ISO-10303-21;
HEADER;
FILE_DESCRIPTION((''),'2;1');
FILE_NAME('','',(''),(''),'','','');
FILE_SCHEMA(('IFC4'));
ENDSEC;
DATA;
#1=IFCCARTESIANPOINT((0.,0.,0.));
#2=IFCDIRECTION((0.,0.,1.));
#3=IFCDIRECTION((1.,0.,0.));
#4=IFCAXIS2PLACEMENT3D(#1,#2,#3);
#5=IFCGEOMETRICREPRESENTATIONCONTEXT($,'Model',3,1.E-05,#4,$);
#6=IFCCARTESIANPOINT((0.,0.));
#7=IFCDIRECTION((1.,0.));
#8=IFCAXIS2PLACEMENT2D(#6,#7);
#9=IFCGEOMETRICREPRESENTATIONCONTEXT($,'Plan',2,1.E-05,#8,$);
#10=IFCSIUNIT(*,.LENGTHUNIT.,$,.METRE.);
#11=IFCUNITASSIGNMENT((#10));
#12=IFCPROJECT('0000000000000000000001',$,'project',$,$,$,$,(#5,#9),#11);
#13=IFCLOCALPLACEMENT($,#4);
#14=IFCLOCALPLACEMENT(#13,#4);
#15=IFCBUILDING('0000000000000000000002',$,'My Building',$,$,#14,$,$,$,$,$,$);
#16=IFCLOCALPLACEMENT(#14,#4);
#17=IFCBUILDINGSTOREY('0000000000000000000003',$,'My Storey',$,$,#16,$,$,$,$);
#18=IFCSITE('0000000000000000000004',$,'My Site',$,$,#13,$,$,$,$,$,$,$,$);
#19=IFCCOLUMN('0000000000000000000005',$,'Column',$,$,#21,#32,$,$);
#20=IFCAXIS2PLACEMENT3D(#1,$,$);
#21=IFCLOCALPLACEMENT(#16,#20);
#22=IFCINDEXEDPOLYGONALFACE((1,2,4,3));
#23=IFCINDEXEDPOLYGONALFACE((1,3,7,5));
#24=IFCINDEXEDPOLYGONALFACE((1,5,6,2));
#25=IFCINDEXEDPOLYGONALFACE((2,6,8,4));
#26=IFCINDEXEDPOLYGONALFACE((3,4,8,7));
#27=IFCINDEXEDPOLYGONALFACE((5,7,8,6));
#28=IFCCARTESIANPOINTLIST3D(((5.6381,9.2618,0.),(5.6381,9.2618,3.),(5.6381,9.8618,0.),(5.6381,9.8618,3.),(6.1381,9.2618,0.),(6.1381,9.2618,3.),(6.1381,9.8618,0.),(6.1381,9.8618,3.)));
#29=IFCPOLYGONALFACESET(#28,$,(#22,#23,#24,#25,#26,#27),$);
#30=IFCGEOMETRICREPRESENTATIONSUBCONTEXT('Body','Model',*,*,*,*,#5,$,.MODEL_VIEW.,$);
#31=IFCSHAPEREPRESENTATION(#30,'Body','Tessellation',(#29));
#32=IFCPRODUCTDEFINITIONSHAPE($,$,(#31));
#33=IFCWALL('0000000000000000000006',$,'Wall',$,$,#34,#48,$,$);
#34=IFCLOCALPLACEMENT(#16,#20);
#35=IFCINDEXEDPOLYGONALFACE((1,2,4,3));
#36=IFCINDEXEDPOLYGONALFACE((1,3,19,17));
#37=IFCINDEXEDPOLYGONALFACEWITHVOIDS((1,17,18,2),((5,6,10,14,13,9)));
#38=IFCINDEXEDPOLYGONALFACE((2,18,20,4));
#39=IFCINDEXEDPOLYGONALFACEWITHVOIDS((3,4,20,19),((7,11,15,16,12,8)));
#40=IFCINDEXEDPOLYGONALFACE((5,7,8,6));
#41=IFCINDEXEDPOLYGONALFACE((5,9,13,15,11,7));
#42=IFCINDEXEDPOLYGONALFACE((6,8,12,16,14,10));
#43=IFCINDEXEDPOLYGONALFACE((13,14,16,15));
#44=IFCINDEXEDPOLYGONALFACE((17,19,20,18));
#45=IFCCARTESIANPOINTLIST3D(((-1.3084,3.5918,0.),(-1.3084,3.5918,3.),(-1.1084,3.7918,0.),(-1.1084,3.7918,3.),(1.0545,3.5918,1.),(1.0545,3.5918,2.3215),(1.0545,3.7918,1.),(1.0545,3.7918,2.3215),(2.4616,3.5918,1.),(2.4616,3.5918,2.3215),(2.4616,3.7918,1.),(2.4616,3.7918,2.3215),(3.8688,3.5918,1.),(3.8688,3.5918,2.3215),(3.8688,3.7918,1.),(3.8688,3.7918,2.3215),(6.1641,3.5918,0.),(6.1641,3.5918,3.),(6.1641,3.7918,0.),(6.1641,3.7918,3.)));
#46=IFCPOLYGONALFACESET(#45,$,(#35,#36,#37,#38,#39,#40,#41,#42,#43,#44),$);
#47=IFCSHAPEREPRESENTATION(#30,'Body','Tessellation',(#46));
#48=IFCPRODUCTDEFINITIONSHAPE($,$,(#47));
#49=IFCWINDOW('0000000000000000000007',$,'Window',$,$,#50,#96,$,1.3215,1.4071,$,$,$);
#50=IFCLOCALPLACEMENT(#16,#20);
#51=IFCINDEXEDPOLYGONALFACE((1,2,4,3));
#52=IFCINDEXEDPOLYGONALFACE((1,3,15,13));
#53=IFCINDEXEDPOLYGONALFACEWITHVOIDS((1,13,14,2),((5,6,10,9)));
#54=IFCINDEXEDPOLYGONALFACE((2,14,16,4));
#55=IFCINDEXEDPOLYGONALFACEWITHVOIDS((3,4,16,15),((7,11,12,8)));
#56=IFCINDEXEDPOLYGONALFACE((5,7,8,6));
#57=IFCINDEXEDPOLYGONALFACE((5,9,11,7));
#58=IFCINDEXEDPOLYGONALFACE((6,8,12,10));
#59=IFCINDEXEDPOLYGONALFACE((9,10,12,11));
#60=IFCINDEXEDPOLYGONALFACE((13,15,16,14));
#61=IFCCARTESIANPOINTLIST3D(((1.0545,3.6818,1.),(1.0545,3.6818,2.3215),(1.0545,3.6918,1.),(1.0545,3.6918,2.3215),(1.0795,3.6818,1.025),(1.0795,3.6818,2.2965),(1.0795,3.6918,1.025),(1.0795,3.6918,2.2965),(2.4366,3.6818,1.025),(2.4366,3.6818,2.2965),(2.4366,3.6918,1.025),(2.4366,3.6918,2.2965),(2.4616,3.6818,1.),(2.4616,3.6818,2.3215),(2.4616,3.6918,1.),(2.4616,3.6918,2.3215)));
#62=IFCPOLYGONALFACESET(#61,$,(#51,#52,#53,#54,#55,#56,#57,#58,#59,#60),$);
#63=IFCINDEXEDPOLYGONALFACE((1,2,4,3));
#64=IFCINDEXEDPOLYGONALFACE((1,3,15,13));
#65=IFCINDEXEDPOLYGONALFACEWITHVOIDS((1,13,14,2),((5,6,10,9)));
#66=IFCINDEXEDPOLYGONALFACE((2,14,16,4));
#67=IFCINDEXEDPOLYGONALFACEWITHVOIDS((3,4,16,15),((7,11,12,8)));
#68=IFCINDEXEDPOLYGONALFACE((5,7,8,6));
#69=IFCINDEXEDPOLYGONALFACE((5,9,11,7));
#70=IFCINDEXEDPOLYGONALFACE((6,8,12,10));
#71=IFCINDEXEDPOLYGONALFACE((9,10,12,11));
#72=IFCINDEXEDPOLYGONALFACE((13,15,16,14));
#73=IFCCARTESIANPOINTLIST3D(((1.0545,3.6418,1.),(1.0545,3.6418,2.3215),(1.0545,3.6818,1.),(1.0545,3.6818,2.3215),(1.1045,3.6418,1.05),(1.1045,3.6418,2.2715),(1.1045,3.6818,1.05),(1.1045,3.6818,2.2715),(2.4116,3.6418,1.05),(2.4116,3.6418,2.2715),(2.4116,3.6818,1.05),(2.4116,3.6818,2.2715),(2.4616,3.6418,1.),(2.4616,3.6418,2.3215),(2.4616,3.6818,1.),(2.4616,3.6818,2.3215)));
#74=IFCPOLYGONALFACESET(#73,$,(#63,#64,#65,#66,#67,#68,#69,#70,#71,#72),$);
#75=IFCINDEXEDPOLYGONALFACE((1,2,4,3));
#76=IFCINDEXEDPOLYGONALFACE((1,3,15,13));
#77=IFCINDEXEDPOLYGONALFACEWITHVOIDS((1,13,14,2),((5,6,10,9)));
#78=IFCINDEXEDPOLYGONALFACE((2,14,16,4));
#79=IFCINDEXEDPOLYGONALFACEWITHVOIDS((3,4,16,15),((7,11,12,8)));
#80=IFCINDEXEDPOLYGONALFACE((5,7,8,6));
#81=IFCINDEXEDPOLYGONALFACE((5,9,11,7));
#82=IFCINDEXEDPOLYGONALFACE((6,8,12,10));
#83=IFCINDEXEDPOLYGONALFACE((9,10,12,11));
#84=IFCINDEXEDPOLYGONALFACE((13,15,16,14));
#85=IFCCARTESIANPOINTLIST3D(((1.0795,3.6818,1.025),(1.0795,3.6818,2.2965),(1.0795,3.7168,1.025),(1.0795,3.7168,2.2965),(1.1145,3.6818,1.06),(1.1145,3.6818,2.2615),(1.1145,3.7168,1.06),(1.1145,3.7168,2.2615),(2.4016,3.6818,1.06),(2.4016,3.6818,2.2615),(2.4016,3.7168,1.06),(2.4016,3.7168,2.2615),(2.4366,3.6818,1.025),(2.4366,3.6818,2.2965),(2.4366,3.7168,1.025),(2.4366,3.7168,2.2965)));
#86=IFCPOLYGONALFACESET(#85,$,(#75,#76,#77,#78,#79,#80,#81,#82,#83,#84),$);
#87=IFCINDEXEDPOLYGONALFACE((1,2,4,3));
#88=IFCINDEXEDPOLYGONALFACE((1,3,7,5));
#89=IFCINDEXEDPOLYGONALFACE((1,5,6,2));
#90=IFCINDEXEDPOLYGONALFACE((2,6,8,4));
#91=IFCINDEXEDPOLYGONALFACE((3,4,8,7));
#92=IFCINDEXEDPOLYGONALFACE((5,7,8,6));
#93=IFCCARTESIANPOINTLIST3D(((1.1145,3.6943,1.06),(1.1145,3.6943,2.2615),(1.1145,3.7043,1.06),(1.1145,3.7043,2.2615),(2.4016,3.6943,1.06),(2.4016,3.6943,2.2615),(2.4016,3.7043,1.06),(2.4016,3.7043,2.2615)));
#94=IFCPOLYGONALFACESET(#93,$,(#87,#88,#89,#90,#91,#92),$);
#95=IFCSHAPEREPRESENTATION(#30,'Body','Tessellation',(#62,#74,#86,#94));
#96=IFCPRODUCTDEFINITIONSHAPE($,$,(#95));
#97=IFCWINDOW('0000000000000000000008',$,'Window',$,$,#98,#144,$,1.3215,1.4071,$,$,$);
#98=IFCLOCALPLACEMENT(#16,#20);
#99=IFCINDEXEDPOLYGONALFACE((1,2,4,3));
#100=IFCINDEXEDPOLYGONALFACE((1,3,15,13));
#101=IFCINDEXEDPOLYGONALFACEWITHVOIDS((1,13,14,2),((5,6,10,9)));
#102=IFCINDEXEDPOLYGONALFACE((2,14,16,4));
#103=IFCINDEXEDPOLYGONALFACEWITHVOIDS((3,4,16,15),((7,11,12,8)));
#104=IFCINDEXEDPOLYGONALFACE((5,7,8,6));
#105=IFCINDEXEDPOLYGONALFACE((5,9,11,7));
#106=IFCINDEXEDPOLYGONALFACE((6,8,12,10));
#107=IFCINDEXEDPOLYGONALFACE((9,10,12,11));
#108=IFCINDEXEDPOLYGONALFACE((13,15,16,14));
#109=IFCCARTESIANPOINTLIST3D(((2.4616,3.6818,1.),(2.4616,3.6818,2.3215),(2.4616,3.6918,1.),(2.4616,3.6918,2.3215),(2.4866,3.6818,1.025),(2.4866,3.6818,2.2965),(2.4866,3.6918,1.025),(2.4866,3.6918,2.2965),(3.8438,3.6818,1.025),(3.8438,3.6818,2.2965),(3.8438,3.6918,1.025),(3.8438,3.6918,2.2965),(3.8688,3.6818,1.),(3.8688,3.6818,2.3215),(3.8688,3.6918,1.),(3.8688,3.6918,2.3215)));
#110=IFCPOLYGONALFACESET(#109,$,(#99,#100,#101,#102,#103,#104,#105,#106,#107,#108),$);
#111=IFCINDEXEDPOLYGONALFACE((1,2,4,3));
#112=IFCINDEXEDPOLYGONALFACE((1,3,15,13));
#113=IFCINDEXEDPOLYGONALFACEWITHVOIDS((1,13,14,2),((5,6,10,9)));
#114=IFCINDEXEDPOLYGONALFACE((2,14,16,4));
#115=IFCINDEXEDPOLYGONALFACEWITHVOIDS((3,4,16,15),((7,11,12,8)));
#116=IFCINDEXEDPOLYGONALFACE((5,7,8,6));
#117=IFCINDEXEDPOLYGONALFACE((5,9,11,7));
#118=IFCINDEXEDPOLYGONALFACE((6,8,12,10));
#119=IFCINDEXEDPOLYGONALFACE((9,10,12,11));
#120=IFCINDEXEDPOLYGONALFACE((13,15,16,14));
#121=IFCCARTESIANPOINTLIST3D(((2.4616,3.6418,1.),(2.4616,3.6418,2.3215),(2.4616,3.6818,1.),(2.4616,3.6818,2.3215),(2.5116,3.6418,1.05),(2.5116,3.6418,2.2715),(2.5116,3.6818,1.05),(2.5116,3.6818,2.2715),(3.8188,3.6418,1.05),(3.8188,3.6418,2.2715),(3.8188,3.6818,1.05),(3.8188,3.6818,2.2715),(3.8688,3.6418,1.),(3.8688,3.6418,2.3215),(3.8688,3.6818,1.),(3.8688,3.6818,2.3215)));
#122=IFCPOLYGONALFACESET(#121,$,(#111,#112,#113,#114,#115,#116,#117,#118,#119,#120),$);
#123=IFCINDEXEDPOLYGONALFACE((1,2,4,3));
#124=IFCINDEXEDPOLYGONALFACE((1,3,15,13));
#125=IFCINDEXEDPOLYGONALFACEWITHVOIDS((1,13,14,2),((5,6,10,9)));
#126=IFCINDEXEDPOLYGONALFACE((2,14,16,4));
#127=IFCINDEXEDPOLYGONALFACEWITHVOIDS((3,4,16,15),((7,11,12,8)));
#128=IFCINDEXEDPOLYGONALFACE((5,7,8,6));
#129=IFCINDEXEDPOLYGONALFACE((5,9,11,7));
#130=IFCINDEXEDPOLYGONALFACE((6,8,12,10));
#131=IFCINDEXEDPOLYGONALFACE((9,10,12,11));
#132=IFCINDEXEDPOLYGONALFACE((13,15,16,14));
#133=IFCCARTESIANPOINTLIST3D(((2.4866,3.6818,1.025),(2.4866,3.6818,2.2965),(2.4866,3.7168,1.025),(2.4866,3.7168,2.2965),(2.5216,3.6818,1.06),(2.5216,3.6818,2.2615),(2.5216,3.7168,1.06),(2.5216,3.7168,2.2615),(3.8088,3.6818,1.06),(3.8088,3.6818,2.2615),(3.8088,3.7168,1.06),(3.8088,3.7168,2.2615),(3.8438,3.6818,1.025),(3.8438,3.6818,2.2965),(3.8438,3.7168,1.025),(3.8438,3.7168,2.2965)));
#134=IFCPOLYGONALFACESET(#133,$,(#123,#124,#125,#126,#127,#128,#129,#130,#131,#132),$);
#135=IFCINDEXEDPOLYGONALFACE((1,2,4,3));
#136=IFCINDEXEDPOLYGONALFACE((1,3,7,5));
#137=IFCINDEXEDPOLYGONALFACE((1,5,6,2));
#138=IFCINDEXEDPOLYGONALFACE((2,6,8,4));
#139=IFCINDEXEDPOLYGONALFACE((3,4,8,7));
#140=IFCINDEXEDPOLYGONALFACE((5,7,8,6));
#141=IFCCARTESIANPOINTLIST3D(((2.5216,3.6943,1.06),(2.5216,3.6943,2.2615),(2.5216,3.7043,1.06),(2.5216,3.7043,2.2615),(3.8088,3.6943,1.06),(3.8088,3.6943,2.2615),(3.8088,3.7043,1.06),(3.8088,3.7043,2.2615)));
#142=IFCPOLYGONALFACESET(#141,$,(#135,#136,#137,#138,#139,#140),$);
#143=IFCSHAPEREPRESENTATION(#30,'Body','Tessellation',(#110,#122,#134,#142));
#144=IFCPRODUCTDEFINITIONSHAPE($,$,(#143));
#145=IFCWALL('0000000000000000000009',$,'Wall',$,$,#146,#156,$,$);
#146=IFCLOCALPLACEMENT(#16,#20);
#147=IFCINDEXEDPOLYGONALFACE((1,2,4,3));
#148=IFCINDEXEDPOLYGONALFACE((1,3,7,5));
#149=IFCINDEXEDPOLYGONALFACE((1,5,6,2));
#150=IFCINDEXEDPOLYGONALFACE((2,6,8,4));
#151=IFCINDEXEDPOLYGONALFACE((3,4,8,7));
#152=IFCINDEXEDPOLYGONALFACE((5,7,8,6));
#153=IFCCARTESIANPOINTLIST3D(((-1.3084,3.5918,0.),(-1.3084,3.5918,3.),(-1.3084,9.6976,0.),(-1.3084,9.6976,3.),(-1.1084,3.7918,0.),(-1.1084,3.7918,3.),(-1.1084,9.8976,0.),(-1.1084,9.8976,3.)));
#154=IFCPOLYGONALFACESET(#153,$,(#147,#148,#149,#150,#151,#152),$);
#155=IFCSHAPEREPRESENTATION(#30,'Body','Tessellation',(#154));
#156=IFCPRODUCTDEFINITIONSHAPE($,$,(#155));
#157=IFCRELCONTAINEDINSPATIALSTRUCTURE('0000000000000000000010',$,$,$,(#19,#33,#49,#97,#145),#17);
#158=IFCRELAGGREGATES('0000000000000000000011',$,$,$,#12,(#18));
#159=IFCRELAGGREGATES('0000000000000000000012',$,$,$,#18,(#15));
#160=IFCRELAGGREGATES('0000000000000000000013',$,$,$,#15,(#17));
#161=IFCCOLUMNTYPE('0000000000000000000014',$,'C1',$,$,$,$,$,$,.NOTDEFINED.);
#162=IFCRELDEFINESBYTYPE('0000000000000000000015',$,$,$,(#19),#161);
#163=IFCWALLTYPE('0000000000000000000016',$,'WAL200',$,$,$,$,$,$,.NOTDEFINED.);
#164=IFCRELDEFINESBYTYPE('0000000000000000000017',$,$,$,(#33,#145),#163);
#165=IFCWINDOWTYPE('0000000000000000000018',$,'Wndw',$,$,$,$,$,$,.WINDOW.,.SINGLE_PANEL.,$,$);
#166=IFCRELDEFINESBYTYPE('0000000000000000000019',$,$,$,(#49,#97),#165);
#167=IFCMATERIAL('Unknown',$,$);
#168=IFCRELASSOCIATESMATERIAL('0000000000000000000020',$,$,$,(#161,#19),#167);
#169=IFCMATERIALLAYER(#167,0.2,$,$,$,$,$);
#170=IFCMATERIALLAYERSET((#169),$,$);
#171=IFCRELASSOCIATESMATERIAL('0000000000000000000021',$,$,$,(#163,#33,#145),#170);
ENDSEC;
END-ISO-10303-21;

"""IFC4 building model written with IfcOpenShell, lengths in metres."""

from ifc_helpers import new_model, entity, si_unit, frame, origin_with_axes, origin_2d_with_axis, place, context, subcontext, project, spatial, line, indexed_curve, rectangle, outline, extrude, shape, source, transform, mapped, material, layer, layer_set, layer_usage, material_profile, profile_set, profile_usage, type_object, type_shapes, element, fill, save


model = new_model("IFC4")

# Units and contexts
model_context = context("Model", 3, precision=1e-05, world=origin_with_axes())
plan_context = context("Plan", 2, precision=1e-05, world=origin_2d_with_axis())
body_context_1 = subcontext(model_context, "Body", "Model", "MODEL_VIEW")
body_context_2 = subcontext(plan_context, "Body", "Plan", "PLAN_VIEW")
ifc_project = project(units=[si_unit("LENGTHUNIT", "METRE")], contexts=[model_context, plan_context])

# Site, building, storey
site_placement = place(None, origin_with_axes())
site = spatial("IfcSite", under=ifc_project, at=site_placement, Name="My Site")
building_placement = place(site_placement, origin_with_axes())
building = spatial("IfcBuilding", under=site, at=building_placement, Name="My Building")
storey_placement = place(building_placement, origin_with_axes())
storey = spatial("IfcBuildingStorey", under=building, at=storey_placement, Name="My Storey")

# Column
ifc_material = material(Name="Unknown")
ifc_material_profile = material_profile(ifc_material, rectangle(XDim=0.5, YDim=0.6))
ifc_profile_set = profile_set([ifc_material_profile])
ifc_profile_usage = profile_usage(ifc_profile_set, cardinal=5)
column_type = type_object("IfcColumnType", Name="C1", PredefinedType="NOTDEFINED", material=ifc_profile_set)
column_placement = place(storey_placement, frame((5.8881, 9.5618, 0.0), z_axis=(0.0, 0.0, 1.0), x_axis=(1.0, 0.0, 0.0)))
element("IfcColumn", 1, at=column_placement, inside=storey, type_object=column_type, material=ifc_profile_usage, Name="Column", context=body_context_1, shape_type="SweptSolid", body=[
    extrude(rectangle(XDim=0.5, YDim=0.6), origin_with_axes(), (0.0, 0.0, 1.0), 3.0),
])

# Wall, openings, windows
ifc_layer = layer(ifc_material, 0.2)
ifc_layer_set = layer_set([ifc_layer])
ifc_layer_usage_1 = layer_usage(ifc_layer_set, "AXIS2", "POSITIVE", 0.0)
wall_type = type_object("IfcWallType", Name="WAL200", PredefinedType="NOTDEFINED", material=ifc_layer_set)
wall_1_placement = place(storey_placement, frame((6.1641, 3.7918, 0.0), z_axis=(0.0, 0.0, 1.0), x_axis=(-1.0, 0.0, 0.0)))
wall_1 = element("IfcWall", 2, at=wall_1_placement, inside=storey, type_object=wall_type, material=ifc_layer_usage_1, Name="Wall", context=body_context_1, shape_type="SweptSolid", body=[
    extrude(outline(indexed_curve([(0.0, 0.0), (0.0, 0.2), (7.4725, 0.2), (7.2725, 0.0)], segments=[line(1, 2, 3, 4, 1)])), origin_with_axes(), (0.0, 0.0, 1.0), 3.0),
])
shared_shape_1 = source(origin_with_axes(), body_context_1, "Body", "SweptSolid", [
    extrude(outline(indexed_curve([(0.0, 0.0), (1.4071, 0.0), (1.4071, 1.3215), (0.0, 1.3215)], segments=[line(1, 2, 3, 4, 1)])), frame((0.0, -0.6, 0.0), z_axis=(0.0, -1.0, 0.0), x_axis=(1.0, 0.0, 0.0)), (0.0, 0.0, -1.0), 1.2),
])
opening_1_placement = place(wall_1_placement, frame((5.1096, 0.2, 1.0), z_axis=(0.0, 0.0, 1.0), x_axis=(-1.0, 0.0, 0.0)))
opening_1 = element("IfcOpeningElement", 3, at=opening_1_placement, cuts=wall_1, PredefinedType="OPENING", context=body_context_1, shape_type="MappedRepresentation", body=[
    mapped(shared_shape_1, transform((0.0, 0.0, 0.0), x_axis=(1.0, 0.0, 0.0), y_axis=(0.0, 1.0, 0.0), z_axis=(0.0, 0.0, 1.0), scale=1.0)),
])
opening_2_placement = place(wall_1_placement, frame((3.7025, 0.2, 1.0), z_axis=(0.0, 0.0, 1.0), x_axis=(-1.0, 0.0, 0.0)))
opening_2 = element("IfcOpeningElement", 4, at=opening_2_placement, cuts=wall_1, PredefinedType="OPENING", context=body_context_1, shape_type="MappedRepresentation", body=[
    mapped(shared_shape_1, transform((0.0, 0.0, 0.0), x_axis=(1.0, 0.0, 0.0), y_axis=(0.0, 1.0, 0.0), z_axis=(0.0, 0.0, 1.0), scale=1.0)),
])
window_type = type_object("IfcWindowType", Name="Wndw", PartitioningType="SINGLE_PANEL", PredefinedType="WINDOW")
shared_shape_2 = source(origin_with_axes(), body_context_1, "Body", "SweptSolid", [
    extrude(outline(indexed_curve([(0.0, 0.0), (1.4071, 0.0), (1.4071, 1.3215), (0.0, 1.3215)], segments=[line(1, 2, 3, 4, 1)]), holes=[indexed_curve([(0.025, 0.025), (1.3821, 0.025), (1.3821, 1.2965), (0.025, 1.2965)], segments=[line(1, 2, 3, 4, 1)])]), frame((0.0, 0.09, 0.0), z_axis=(0.0, -1.0, 0.0), x_axis=(1.0, 0.0, 0.0)), (0.0, 0.0, -1.0), 0.01),
    extrude(outline(indexed_curve([(0.0, 0.0), (1.4071, 0.0), (1.4071, 1.3215), (0.0, 1.3215)], segments=[line(1, 2, 3, 4, 1)]), holes=[indexed_curve([(0.05, 0.05), (1.3571, 0.05), (1.3571, 1.2715), (0.05, 1.2715)], segments=[line(1, 2, 3, 4, 1)])]), frame((0.0, 0.05, 0.0), z_axis=(0.0, -1.0, 0.0), x_axis=(1.0, 0.0, 0.0)), (0.0, 0.0, -1.0), 0.04),
    extrude(outline(indexed_curve([(0.0, 0.0), (1.3571, 0.0), (1.3571, 1.2715), (0.0, 1.2715)], segments=[line(1, 2, 3, 4, 1)]), holes=[indexed_curve([(0.035, 0.035), (1.3221, 0.035), (1.3221, 1.2365), (0.035, 1.2365)], segments=[line(1, 2, 3, 4, 1)])]), frame((0.025, 0.09, 0.025), z_axis=(0.0, -1.0, 0.0), x_axis=(1.0, 0.0, 0.0)), (0.0, 0.0, -1.0), 0.035),
    extrude(outline(indexed_curve([(0.035, 0.035), (1.3221, 0.035), (1.3221, 1.2365), (0.035, 1.2365)], segments=[line(1, 2, 3, 4, 1)])), frame((0.025, 0.1025, 0.025), z_axis=(0.0, -1.0, 0.0), x_axis=(1.0, 0.0, 0.0)), (0.0, 0.0, -1.0), 0.01),
])
shared_shape_3 = source(origin_with_axes(), body_context_2, "Body", "Curve2D", [
    entity("IfcIndexedPolyCurve", entity("IfcCartesianPointList2D", [[0.05, 0.05], [1.3571, 0.05]])),
    entity("IfcIndexedPolyCurve", entity("IfcCartesianPointList2D", [[0.0, 0.1], [0.025, 0.1], [0.025, 0.09], [0.05, 0.09], [0.05, 0.05], [0.0, 0.05]]), [entity("IfcLineIndex", [1, 2, 3, 4, 5, 6, 1])]),
    entity("IfcIndexedPolyCurve", entity("IfcCartesianPointList2D", [[1.4071, 0.1], [1.3821, 0.1], [1.3821, 0.09], [1.3571, 0.09], [1.3571, 0.05], [1.4071, 0.05]]), [entity("IfcLineIndex", [1, 2, 3, 4, 5, 6, 1])]),
    entity("IfcIndexedPolyCurve", entity("IfcCartesianPointList2D", [[0.025, 0.09], [0.06, 0.09], [0.06, 0.125], [0.025, 0.125]]), [entity("IfcLineIndex", [1, 2, 3, 4, 1])]),
    entity("IfcIndexedPolyCurve", entity("IfcCartesianPointList2D", [[1.3821, 0.09], [1.3471, 0.09], [1.3471, 0.125], [1.3821, 0.125]]), [entity("IfcLineIndex", [1, 2, 3, 4, 1])]),
    entity("IfcIndexedPolyCurve", entity("IfcCartesianPointList2D", [[0.06, 0.09], [1.3471, 0.09]])),
    entity("IfcIndexedPolyCurve", entity("IfcCartesianPointList2D", [[0.06, 0.125], [1.3471, 0.125]])),
    entity("IfcIndexedPolyCurve", entity("IfcCartesianPointList2D", [[0.06, 0.1075], [1.3471, 0.1075]])),
])
type_shapes(window_type, [shared_shape_2, shared_shape_3])
window_1_placement = place(opening_1_placement, frame((0.0, 0.0, 0.0), z_axis=(0.0, 0.0, 1.0), x_axis=(1.0, 0.0, 0.0)))
window_1 = element("IfcWindow", 5, at=window_1_placement, inside=storey, type_object=window_type, Name="Window", OverallHeight=1.3215, OverallWidth=1.4071, shapes=[
    shape(body_context_1, "Body", "MappedRepresentation", [mapped(shared_shape_2, transform((0.0, 0.0, 0.0), x_axis=(1.0, 0.0, 0.0), y_axis=(0.0, 1.0, 0.0), z_axis=(0.0, 0.0, 1.0), scale=1.0))]),
    shape(body_context_2, "Body", "MappedRepresentation", [mapped(shared_shape_3, transform((0.0, 0.0, 0.0), x_axis=(1.0, 0.0, 0.0), y_axis=(0.0, 1.0, 0.0), z_axis=(0.0, 0.0, 1.0), scale=1.0))]),
])
fill(opening_1, window_1)
window_2_placement = place(opening_2_placement, frame((0.0, 0.0, 0.0), z_axis=(0.0, 0.0, 1.0), x_axis=(1.0, 0.0, 0.0)))
window_2 = element("IfcWindow", 6, at=window_2_placement, inside=storey, type_object=window_type, Name="Window", OverallHeight=1.3215, OverallWidth=1.4071, shapes=[
    shape(body_context_1, "Body", "MappedRepresentation", [mapped(shared_shape_2, transform((0.0, 0.0, 0.0), x_axis=(1.0, 0.0, 0.0), y_axis=(0.0, 1.0, 0.0), z_axis=(0.0, 0.0, 1.0), scale=1.0))]),
    shape(body_context_2, "Body", "MappedRepresentation", [mapped(shared_shape_3, transform((0.0, 0.0, 0.0), x_axis=(1.0, 0.0, 0.0), y_axis=(0.0, 1.0, 0.0), z_axis=(0.0, 0.0, 1.0), scale=1.0))]),
])
fill(opening_2, window_2)

# Wall
ifc_layer_usage_2 = layer_usage(ifc_layer_set, "AXIS2", "POSITIVE", 0.0)
wall_2_placement = place(storey_placement, frame((-1.1084, 3.7918, 0.0), z_axis=(0.0, 0.0, 1.0), x_axis=(0.0, 1.0, 0.0)))
element("IfcWall", 7, at=wall_2_placement, inside=storey, type_object=wall_type, material=ifc_layer_usage_2, Name="Wall", context=body_context_1, shape_type="SweptSolid", body=[
    extrude(outline(indexed_curve([(0.0, 0.0), (-0.2, 0.2), (5.9058, 0.2), (6.1058, 0.0)], segments=[line(1, 2, 3, 4, 1)])), origin_with_axes(), (0.0, 0.0, 1.0), 3.0),
])

save(model, "model.ifc")
